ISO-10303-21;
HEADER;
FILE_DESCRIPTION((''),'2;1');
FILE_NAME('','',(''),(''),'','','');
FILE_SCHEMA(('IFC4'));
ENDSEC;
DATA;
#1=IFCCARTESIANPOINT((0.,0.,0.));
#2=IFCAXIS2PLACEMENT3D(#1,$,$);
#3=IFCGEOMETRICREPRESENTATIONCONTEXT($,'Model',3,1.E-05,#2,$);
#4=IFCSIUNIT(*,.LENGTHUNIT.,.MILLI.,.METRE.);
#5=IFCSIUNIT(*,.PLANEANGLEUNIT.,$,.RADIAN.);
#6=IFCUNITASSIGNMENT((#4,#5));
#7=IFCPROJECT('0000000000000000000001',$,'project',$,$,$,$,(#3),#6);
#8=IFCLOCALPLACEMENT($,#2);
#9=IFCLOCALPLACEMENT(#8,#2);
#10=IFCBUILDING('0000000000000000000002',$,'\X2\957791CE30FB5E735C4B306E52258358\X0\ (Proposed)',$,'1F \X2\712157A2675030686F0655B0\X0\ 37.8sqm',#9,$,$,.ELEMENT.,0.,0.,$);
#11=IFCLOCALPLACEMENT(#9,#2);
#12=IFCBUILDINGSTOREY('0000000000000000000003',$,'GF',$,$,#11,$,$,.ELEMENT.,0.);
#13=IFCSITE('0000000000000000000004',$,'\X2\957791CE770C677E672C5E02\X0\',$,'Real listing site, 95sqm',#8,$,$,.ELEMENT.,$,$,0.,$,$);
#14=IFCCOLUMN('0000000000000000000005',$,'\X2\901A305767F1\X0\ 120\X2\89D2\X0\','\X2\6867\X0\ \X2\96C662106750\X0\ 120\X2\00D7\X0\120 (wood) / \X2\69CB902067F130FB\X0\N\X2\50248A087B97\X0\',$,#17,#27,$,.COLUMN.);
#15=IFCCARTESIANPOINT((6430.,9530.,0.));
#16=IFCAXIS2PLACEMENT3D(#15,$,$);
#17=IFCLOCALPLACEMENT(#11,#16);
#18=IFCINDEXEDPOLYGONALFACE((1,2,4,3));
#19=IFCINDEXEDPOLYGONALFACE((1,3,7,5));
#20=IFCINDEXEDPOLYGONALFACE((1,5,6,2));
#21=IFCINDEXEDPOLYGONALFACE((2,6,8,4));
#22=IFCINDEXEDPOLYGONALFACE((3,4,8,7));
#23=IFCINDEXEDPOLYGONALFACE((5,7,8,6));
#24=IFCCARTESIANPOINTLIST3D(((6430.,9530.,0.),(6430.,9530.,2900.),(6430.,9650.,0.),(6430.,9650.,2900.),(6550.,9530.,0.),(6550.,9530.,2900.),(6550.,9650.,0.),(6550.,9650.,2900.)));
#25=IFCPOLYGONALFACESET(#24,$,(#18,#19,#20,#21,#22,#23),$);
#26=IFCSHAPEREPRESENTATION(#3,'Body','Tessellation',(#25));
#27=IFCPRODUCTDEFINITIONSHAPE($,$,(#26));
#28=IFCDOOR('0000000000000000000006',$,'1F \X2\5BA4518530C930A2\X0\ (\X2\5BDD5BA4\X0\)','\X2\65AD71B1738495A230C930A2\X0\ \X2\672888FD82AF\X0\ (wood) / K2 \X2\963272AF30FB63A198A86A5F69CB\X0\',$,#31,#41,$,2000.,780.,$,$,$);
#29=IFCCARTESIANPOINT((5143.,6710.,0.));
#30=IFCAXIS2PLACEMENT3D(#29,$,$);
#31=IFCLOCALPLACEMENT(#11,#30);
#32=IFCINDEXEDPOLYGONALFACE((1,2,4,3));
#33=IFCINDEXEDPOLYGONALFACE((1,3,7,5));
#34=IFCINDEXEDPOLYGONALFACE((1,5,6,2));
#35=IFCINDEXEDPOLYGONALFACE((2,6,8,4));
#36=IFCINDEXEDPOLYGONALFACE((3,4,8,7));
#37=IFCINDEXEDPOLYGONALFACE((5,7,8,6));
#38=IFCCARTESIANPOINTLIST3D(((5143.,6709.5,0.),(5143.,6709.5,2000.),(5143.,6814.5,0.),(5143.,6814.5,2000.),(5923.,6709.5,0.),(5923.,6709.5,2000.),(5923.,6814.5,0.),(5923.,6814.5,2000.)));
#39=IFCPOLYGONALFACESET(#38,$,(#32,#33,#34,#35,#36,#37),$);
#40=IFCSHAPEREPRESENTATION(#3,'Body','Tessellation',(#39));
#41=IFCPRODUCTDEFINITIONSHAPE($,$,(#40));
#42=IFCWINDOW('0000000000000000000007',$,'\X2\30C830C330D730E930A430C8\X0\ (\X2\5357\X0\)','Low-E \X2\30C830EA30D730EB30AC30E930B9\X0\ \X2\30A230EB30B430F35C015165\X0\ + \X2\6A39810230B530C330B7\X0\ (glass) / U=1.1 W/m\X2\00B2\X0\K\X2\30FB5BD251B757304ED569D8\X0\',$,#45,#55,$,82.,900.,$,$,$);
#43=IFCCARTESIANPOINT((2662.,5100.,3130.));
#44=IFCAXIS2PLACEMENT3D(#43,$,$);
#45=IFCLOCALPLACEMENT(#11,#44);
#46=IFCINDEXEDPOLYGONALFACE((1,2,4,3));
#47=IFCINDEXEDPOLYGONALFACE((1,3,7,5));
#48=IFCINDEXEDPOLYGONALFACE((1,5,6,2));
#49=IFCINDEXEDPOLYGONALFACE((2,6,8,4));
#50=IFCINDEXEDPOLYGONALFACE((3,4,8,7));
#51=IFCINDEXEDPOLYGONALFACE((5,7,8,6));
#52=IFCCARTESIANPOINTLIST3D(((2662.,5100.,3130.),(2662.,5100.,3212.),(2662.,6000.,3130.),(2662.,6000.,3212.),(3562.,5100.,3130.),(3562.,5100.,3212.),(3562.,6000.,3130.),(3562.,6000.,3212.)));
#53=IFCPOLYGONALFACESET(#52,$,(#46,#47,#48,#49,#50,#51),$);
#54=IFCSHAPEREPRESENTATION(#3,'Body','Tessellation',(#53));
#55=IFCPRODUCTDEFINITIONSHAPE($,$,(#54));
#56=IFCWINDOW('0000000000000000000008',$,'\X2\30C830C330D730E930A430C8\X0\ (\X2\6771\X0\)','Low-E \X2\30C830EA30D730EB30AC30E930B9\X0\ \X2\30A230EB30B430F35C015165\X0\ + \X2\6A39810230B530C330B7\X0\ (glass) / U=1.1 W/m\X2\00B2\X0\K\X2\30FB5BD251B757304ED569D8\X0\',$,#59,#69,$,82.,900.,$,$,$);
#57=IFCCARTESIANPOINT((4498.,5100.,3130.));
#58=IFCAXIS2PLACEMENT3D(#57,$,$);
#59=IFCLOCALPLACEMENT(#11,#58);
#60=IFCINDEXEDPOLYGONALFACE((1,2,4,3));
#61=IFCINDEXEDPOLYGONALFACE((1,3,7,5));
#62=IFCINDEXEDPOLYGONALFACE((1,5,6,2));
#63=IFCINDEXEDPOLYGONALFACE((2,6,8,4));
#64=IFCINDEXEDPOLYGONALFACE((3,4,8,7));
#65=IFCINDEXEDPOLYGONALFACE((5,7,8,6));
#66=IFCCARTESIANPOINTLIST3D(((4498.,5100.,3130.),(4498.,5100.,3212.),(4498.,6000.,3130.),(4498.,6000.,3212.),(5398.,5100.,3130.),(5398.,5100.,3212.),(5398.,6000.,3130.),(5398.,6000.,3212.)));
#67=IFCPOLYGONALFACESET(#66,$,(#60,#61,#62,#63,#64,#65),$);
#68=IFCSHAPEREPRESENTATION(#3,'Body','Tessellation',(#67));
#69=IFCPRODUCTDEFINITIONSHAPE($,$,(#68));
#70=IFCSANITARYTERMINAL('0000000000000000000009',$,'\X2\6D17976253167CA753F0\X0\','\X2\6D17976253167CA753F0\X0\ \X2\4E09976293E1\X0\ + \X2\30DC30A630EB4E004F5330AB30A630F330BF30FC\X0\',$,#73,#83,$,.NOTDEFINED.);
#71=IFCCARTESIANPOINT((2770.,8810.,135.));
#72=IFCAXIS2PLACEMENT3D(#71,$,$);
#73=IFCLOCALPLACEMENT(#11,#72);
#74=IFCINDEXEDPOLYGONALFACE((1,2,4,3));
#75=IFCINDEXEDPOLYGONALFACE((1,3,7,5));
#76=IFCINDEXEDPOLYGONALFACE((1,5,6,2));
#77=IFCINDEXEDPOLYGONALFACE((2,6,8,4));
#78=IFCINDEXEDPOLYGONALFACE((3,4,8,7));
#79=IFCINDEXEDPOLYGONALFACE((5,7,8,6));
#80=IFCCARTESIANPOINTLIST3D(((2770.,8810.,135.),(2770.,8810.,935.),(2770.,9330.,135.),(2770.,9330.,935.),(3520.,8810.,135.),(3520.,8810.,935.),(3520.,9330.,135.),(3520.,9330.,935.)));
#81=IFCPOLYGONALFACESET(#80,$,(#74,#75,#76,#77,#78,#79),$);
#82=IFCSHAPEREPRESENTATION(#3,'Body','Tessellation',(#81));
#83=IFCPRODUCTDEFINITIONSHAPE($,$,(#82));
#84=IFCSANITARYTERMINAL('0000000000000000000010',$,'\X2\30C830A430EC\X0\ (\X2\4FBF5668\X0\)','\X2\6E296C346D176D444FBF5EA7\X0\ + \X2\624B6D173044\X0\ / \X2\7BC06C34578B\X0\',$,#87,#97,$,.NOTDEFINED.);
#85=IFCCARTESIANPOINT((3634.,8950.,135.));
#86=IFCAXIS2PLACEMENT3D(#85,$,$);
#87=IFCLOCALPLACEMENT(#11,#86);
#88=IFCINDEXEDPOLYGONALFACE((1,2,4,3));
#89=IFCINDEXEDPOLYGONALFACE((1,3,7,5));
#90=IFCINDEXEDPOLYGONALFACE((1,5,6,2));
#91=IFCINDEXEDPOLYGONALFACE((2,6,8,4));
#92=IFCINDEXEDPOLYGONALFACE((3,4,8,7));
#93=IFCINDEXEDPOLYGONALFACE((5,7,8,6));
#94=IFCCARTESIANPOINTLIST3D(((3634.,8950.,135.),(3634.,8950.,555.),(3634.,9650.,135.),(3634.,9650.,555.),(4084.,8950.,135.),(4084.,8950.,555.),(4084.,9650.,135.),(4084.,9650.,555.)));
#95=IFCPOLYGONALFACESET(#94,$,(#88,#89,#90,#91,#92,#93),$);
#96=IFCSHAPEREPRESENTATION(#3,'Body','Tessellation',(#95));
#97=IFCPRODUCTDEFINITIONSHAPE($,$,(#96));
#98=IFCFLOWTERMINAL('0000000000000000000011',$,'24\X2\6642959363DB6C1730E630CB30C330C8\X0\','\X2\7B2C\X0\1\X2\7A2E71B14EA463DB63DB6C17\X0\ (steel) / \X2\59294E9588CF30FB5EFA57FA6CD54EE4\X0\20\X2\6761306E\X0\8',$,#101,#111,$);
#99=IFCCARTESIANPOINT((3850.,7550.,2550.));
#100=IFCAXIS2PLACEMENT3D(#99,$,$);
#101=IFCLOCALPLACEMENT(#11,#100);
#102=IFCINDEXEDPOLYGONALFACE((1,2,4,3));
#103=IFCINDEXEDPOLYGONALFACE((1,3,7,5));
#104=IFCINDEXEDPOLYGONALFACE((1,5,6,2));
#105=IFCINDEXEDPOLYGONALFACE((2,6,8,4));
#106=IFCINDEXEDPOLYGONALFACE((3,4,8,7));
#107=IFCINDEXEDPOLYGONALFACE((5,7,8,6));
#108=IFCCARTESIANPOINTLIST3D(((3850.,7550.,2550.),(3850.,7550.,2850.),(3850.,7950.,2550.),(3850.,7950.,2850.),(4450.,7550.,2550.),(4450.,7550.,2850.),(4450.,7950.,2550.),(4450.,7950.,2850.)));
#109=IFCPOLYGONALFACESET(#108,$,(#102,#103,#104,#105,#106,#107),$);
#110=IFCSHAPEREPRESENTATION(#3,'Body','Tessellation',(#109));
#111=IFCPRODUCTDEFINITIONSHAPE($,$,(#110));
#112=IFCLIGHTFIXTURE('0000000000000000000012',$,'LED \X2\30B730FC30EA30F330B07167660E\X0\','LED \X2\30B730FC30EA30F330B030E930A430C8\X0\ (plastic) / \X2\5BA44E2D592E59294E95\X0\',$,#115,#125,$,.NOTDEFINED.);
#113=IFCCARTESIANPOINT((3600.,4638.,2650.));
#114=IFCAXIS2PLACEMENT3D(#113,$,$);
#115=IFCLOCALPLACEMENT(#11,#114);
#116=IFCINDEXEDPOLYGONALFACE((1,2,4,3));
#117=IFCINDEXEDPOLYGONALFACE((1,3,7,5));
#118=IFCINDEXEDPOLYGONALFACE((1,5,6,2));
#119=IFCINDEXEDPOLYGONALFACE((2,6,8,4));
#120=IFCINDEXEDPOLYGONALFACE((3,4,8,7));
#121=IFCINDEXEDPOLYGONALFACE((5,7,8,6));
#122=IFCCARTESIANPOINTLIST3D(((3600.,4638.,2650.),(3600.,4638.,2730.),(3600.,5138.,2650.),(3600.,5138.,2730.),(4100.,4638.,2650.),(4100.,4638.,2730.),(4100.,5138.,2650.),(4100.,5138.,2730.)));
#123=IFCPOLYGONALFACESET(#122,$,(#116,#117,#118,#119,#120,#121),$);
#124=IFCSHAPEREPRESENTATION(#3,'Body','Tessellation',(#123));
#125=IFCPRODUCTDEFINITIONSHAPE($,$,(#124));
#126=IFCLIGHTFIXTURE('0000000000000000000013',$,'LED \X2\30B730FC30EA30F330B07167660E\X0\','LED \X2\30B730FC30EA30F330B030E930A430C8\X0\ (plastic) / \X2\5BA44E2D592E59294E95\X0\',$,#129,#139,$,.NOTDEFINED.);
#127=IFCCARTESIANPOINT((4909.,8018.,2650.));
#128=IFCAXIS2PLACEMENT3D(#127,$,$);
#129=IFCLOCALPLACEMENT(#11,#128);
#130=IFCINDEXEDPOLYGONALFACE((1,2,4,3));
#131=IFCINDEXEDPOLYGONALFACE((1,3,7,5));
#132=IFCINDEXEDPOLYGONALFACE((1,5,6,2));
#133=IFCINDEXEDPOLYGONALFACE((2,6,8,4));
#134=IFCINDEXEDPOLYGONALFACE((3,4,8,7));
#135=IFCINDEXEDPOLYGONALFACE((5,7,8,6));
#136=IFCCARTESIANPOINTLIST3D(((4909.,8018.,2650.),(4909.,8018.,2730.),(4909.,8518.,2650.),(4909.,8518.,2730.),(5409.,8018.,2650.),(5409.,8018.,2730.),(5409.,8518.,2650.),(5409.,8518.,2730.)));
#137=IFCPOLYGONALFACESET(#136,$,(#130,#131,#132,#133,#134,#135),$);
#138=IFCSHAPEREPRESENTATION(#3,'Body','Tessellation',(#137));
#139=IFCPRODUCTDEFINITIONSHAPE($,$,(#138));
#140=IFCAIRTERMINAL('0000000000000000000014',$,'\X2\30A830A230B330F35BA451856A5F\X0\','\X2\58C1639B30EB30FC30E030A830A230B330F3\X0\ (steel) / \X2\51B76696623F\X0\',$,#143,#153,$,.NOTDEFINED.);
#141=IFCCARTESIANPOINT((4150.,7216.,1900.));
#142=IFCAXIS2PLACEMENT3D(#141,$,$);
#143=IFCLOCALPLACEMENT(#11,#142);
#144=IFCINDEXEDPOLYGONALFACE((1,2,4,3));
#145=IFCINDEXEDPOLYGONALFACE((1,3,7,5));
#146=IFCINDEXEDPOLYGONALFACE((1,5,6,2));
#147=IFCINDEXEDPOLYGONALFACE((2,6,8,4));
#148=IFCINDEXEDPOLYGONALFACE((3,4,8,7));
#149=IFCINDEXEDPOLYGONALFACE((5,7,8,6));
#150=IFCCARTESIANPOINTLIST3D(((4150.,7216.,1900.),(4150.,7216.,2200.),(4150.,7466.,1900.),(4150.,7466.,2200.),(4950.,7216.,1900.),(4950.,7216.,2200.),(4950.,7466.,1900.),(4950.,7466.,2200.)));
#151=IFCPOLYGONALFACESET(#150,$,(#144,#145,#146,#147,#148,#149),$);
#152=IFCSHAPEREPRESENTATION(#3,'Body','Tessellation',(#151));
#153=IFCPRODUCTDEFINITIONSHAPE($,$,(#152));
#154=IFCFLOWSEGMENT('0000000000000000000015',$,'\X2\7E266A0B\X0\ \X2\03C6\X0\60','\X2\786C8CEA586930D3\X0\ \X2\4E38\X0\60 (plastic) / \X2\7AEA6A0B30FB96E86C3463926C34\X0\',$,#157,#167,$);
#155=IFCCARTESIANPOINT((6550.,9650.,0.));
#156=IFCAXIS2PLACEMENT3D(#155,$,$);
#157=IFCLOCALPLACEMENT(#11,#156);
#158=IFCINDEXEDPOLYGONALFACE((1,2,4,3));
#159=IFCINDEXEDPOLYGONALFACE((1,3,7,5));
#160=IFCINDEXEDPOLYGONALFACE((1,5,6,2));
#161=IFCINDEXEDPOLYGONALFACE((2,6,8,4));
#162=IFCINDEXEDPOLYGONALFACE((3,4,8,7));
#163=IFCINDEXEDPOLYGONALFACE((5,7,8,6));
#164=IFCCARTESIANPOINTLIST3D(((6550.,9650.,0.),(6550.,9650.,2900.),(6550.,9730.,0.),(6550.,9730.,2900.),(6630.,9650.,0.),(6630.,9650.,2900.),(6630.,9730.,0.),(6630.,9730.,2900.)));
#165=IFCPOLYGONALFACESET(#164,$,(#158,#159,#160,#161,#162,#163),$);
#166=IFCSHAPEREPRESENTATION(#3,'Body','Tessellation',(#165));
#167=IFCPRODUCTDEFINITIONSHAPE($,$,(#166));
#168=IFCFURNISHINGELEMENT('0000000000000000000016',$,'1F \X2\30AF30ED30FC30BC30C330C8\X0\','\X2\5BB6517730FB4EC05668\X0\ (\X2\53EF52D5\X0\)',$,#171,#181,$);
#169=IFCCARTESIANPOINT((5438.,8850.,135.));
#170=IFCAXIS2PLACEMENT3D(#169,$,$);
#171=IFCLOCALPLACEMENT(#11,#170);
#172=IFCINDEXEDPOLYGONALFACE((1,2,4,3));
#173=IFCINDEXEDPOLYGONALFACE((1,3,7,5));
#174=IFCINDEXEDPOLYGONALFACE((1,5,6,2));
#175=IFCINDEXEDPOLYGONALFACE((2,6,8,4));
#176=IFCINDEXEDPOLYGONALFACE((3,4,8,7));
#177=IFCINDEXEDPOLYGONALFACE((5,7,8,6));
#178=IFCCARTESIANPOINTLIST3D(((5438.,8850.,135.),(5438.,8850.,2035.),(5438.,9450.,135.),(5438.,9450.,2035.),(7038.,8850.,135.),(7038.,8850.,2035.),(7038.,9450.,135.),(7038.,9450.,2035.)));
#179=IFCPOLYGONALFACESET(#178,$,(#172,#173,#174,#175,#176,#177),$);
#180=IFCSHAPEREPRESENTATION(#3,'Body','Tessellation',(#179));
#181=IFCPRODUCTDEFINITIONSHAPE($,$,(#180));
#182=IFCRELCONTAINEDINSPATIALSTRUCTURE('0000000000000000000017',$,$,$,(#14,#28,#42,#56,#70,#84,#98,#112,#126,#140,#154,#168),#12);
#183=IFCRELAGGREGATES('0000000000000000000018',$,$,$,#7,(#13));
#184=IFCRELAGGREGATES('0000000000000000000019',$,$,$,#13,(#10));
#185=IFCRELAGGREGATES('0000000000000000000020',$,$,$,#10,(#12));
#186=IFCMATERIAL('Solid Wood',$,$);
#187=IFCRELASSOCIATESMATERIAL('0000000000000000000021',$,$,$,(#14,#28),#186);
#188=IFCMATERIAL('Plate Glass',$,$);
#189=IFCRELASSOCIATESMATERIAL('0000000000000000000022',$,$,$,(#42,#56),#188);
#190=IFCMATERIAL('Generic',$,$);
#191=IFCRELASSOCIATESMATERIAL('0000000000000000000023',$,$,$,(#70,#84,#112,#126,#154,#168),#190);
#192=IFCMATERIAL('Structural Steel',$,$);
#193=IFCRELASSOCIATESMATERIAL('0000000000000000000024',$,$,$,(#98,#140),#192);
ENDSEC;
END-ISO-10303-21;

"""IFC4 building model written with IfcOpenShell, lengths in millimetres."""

from ifc_helpers import new_model, si_unit, frame, frame_2d, origin, place, context, project, spatial, rectangle, extrude, material, element, save


model = new_model("IFC4")

# Units and contexts
model_context = context("Model", 3, precision=1e-05, world=origin())
ifc_project = project(units=[si_unit("LENGTHUNIT", "METRE", prefix="MILLI"), si_unit("PLANEANGLEUNIT", "RADIAN")], contexts=[model_context])

# Site, building, storey
site_placement = place(None, origin())
site = spatial("IfcSite", under=ifc_project, at=site_placement, Name="長野県松本市", ObjectType="Real listing site, 95sqm", CompositionType="ELEMENT", RefElevation=0.0)
building_placement = place(site_placement, origin())
building = spatial("IfcBuilding", under=site, at=building_placement, Name="長野・平屋の別荘 (Proposed)", ObjectType="1F 無垢材と漆喰 37.8sqm", CompositionType="ELEMENT", ElevationOfRefHeight=0.0, ElevationOfTerrain=0.0)
storey_placement = place(building_placement, origin())
storey = spatial("IfcBuildingStorey", under=building, at=storey_placement, Name="GF", CompositionType="ELEMENT", Elevation=0.0)

# Column
ifc_material_1 = material(Name="Solid Wood")
column_1_placement = place(storey_placement, frame((6430.0, 9530.0, 0.0)))
element("IfcColumn", 1, at=column_1_placement, inside=storey, material=ifc_material_1, Name="通し柱 120角", Description="桧 集成材 120×120 (wood) / 構造柱・N値計算", PredefinedType="COLUMN", context=model_context, shape_type="SweptSolid", body=[
    extrude(rectangle(XDim=120.0, YDim=120.0, at=frame_2d((60.0, 60.0))), frame((6430.0, 9530.0, 0.0)), (0.0, 0.0, 1.0), 2900.0),
])

# Door
door_placement = place(storey_placement, frame((5143.0, 6710.0, 0.0)))
element("IfcDoor", 2, at=door_placement, inside=storey, material=ifc_material_1, Name="1F 室内ドア (寝室)", Description="断熱玄関ドア 木製芯 (wood) / K2 防犯・採風機構", OverallHeight=2000.0, OverallWidth=780.0, context=model_context, shape_type="SweptSolid", body=[
    extrude(rectangle(XDim=780.0, YDim=105.0, at=frame_2d((390.0, 52.0))), frame((5143.0, 6710.0, 0.0)), (0.0, 0.0, 1.0), 2000.0),
])

# Windows
ifc_material_2 = material(Name="Plate Glass")
window_1_placement = place(storey_placement, frame((2662.0, 5100.0, 3130.0)))
element("IfcWindow", 3, at=window_1_placement, inside=storey, material=ifc_material_2, Name="トップライト (南)", Description="Low-E トリプルガラス アルゴン封入 + 樹脂サッシ (glass) / U=1.1 W/m²K・寒冷地仕様", OverallHeight=82.0, OverallWidth=900.0, context=model_context, shape_type="SweptSolid", body=[
    extrude(rectangle(XDim=900.0, YDim=900.0, at=frame_2d((450.0, 450.0))), frame((2662.0, 5100.0, 3130.0)), (0.0, 0.0, 1.0), 82.0),
])
window_2_placement = place(storey_placement, frame((4498.0, 5100.0, 3130.0)))
element("IfcWindow", 4, at=window_2_placement, inside=storey, material=ifc_material_2, Name="トップライト (東)", Description="Low-E トリプルガラス アルゴン封入 + 樹脂サッシ (glass) / U=1.1 W/m²K・寒冷地仕様", OverallHeight=82.0, OverallWidth=900.0, context=model_context, shape_type="SweptSolid", body=[
    extrude(rectangle(XDim=900.0, YDim=900.0, at=frame_2d((450.0, 450.0))), frame((4498.0, 5100.0, 3130.0)), (0.0, 0.0, 1.0), 82.0),
])

# Sanitary terminals
ifc_material_3 = material(Name="Generic")
sanitary_terminal_1_placement = place(storey_placement, frame((2770.0, 8810.0, 135.0)))
element("IfcSanitaryTerminal", 5, at=sanitary_terminal_1_placement, inside=storey, material=ifc_material_3, Name="洗面化粧台", Description="洗面化粧台 三面鏡 + ボウル一体カウンター", PredefinedType="NOTDEFINED", context=model_context, shape_type="SweptSolid", body=[
    extrude(rectangle(XDim=750.0, YDim=520.0, at=frame_2d((375.0, 260.0))), frame((2770.0, 8810.0, 135.0)), (0.0, 0.0, 1.0), 800.0),
])
sanitary_terminal_2_placement = place(storey_placement, frame((3634.0, 8950.0, 135.0)))
element("IfcSanitaryTerminal", 6, at=sanitary_terminal_2_placement, inside=storey, material=ifc_material_3, Name="トイレ (便器)", Description="温水洗浄便座 + 手洗い / 節水型", PredefinedType="NOTDEFINED", context=model_context, shape_type="SweptSolid", body=[
    extrude(rectangle(XDim=450.0, YDim=700.0, at=frame_2d((225.0, 350.0))), frame((3634.0, 8950.0, 135.0)), (0.0, 0.0, 1.0), 420.0),
])

# Flow terminal
ifc_material_4 = material(Name="Structural Steel")
flow_terminal_placement = place(storey_placement, frame((3850.0, 7550.0, 2550.0)))
element("IfcFlowTerminal", 7, at=flow_terminal_placement, inside=storey, material=ifc_material_4, Name="24時間換気ユニット", Description="第1種熱交換換気 (steel) / 天井裏・建基法令20条の8", context=model_context, shape_type="SweptSolid", body=[
    extrude(rectangle(XDim=600.0, YDim=400.0, at=frame_2d((300.0, 200.0))), frame((3850.0, 7550.0, 2550.0)), (0.0, 0.0, 1.0), 300.0),
])

# Light fixtures
light_fixture_1_placement = place(storey_placement, frame((3600.0, 4638.0, 2650.0)))
element("IfcLightFixture", 8, at=light_fixture_1_placement, inside=storey, material=ifc_material_3, Name="LED シーリング照明", Description="LED シーリングライト (plastic) / 室中央天井", PredefinedType="NOTDEFINED", context=model_context, shape_type="SweptSolid", body=[
    extrude(rectangle(XDim=500.0, YDim=500.0, at=frame_2d((250.0, 250.0))), frame((3600.0, 4638.0, 2650.0)), (0.0, 0.0, 1.0), 80.0),
])
light_fixture_2_placement = place(storey_placement, frame((4909.0, 8018.0, 2650.0)))
element("IfcLightFixture", 9, at=light_fixture_2_placement, inside=storey, material=ifc_material_3, Name="LED シーリング照明", Description="LED シーリングライト (plastic) / 室中央天井", PredefinedType="NOTDEFINED", context=model_context, shape_type="SweptSolid", body=[
    extrude(rectangle(XDim=500.0, YDim=500.0, at=frame_2d((250.0, 250.0))), frame((4909.0, 8018.0, 2650.0)), (0.0, 0.0, 1.0), 80.0),
])

# Air terminal
air_terminal_placement = place(storey_placement, frame((4150.0, 7216.0, 1900.0)))
element("IfcAirTerminal", 10, at=air_terminal_placement, inside=storey, material=ifc_material_4, Name="エアコン室内機", Description="壁掛ルームエアコン (steel) / 冷暖房", PredefinedType="NOTDEFINED", context=model_context, shape_type="SweptSolid", body=[
    extrude(rectangle(XDim=800.0, YDim=250.0, at=frame_2d((400.0, 125.0))), frame((4150.0, 7216.0, 1900.0)), (0.0, 0.0, 1.0), 300.0),
])

# Flow segment
flow_segment_placement = place(storey_placement, frame((6550.0, 9650.0, 0.0)))
element("IfcFlowSegment", 11, at=flow_segment_placement, inside=storey, material=ifc_material_3, Name="縦樋 φ60", Description="硬質塩ビ 丸60 (plastic) / 竪樋・雨水排水", context=model_context, shape_type="SweptSolid", body=[
    extrude(rectangle(XDim=80.0, YDim=80.0, at=frame_2d((40.0, 40.0))), frame((6550.0, 9650.0, 0.0)), (0.0, 0.0, 1.0), 2900.0),
])

# Furnishing element
furnishing_placement = place(storey_placement, frame((5438.0, 8850.0, 135.0)))
element("IfcFurnishingElement", 12, at=furnishing_placement, inside=storey, material=ifc_material_3, Name="1F クローゼット", Description="家具・什器 (可動)", context=model_context, shape_type="SweptSolid", body=[
    extrude(rectangle(XDim=1600.0, YDim=600.0, at=frame_2d((800.0, 300.0))), frame((5438.0, 8850.0, 135.0)), (0.0, 0.0, 1.0), 1900.0),
])

save(model, "model.ifc")
